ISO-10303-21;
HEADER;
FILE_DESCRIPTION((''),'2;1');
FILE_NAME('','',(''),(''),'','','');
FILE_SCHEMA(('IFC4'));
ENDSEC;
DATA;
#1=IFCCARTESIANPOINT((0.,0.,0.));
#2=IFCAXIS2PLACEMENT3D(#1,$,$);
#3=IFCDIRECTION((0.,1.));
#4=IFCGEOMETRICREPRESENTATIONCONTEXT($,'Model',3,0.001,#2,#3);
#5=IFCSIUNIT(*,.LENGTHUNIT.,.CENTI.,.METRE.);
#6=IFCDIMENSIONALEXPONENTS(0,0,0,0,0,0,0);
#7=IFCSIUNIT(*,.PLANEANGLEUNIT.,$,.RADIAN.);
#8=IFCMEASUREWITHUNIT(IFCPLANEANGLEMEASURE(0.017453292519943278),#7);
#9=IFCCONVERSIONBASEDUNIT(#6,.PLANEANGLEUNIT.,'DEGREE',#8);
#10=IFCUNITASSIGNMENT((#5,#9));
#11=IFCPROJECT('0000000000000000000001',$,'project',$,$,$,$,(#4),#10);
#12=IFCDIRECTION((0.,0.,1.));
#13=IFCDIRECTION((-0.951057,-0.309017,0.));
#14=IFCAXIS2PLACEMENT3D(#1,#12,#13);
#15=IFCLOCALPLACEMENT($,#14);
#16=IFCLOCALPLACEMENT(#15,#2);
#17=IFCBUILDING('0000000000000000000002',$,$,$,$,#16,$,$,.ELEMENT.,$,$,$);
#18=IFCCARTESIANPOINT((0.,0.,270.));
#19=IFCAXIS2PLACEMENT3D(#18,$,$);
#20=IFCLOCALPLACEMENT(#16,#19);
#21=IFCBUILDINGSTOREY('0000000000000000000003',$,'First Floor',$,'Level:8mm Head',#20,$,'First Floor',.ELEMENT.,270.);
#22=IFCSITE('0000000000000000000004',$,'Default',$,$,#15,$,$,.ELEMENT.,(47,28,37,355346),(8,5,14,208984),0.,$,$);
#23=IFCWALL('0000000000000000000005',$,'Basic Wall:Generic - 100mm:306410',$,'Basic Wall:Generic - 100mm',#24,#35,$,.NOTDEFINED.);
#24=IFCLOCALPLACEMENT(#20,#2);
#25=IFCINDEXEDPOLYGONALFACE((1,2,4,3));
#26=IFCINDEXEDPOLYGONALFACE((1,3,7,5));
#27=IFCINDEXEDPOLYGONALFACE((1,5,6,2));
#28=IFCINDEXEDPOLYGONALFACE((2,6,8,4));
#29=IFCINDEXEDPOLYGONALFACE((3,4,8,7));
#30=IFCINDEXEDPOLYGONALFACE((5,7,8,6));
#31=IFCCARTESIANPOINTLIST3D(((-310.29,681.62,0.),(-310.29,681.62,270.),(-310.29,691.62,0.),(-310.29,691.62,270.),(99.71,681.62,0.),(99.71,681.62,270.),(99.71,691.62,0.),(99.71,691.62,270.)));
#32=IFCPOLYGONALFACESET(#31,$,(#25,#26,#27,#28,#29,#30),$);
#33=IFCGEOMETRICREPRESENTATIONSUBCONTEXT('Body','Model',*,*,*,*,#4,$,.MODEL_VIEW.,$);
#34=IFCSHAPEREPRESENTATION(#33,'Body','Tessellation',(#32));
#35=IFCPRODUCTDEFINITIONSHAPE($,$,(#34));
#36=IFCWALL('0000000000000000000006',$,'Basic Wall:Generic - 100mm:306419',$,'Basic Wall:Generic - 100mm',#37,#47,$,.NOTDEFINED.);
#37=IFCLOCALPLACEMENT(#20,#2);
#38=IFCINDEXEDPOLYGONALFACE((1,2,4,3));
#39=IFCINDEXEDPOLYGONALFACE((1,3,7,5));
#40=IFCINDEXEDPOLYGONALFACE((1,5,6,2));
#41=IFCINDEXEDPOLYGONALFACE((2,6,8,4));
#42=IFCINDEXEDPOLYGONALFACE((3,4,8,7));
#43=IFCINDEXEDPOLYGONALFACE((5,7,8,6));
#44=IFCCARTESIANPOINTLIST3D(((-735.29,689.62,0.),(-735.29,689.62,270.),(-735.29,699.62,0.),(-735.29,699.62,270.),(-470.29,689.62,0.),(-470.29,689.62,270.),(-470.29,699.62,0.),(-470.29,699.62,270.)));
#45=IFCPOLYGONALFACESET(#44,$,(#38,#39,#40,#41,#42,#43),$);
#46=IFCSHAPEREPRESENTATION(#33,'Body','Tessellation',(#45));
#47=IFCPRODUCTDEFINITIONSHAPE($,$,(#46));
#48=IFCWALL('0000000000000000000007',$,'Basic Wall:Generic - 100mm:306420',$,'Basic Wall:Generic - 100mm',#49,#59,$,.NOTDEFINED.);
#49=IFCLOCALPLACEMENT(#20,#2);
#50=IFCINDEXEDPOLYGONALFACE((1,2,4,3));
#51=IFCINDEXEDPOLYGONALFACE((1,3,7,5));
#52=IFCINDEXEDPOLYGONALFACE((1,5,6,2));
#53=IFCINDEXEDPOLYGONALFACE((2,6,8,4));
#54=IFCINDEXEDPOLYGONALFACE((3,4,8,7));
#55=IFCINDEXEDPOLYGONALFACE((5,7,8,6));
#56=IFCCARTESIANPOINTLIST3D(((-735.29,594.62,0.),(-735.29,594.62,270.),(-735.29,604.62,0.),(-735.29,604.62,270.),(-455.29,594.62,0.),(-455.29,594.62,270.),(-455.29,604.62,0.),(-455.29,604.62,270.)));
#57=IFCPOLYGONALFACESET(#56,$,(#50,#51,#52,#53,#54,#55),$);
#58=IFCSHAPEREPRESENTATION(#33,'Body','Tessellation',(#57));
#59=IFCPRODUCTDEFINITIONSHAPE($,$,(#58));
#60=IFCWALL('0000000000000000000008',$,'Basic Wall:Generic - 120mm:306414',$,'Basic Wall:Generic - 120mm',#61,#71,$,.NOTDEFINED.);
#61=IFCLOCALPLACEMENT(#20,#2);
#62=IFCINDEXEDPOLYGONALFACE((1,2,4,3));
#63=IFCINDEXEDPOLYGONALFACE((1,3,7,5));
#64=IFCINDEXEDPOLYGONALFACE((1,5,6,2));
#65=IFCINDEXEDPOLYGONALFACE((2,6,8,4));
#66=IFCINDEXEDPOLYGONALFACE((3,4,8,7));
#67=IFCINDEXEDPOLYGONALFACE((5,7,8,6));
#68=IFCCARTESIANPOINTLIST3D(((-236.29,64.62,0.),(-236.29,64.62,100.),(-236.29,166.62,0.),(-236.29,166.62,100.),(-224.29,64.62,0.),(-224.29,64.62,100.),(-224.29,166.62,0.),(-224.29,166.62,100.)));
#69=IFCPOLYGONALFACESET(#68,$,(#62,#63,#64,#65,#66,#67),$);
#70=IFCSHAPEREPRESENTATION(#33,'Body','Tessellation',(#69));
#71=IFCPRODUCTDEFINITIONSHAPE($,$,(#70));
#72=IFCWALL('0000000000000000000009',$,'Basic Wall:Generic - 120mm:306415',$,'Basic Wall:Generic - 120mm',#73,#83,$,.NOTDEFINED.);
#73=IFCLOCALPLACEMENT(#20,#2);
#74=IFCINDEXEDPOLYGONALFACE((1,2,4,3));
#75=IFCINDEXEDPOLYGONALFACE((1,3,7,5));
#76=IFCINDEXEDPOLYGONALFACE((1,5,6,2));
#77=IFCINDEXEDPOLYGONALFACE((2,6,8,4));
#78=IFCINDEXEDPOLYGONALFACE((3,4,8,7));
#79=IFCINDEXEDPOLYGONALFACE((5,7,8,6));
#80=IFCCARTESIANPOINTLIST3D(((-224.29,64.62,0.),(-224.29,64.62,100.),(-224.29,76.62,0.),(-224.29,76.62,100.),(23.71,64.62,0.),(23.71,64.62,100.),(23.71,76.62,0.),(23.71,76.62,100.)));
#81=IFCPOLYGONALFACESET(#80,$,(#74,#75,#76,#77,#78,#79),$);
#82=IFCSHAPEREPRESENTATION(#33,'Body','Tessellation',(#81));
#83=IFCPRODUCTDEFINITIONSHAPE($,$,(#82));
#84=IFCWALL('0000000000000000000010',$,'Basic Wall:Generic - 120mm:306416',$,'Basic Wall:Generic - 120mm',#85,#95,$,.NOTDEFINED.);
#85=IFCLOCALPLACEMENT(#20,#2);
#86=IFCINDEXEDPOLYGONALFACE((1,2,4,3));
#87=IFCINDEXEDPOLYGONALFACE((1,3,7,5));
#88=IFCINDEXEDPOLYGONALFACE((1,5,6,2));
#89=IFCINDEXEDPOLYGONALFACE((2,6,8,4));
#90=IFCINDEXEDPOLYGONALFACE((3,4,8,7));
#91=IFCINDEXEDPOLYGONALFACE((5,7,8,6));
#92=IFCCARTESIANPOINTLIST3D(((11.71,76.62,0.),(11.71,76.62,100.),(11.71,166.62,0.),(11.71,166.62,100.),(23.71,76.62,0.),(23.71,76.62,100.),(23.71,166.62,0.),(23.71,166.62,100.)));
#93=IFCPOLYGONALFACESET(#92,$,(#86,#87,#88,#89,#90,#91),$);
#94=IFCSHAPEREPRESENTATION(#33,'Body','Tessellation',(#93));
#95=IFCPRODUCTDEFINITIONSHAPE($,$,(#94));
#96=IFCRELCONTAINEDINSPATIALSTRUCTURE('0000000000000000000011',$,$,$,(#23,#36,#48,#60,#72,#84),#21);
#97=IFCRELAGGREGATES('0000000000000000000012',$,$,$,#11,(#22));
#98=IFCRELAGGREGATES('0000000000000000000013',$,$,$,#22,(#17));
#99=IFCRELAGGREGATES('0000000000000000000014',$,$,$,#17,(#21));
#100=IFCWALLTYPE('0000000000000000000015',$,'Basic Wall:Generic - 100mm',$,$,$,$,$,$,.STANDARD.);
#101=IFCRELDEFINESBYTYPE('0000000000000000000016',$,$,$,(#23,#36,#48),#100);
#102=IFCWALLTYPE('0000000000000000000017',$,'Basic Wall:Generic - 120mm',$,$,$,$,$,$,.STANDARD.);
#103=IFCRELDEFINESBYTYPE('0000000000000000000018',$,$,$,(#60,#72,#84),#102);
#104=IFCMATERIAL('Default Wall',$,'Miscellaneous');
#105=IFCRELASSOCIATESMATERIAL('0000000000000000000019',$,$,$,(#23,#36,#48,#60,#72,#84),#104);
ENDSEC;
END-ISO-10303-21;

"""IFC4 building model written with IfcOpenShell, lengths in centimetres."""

from ifc_helpers import new_model, entity, si_unit, converted_unit, direction, frame, origin, place, context, subcontext, project, spatial, indexed_curve, outline, extrude, material, type_object, element, save


model = new_model("IFC4")

# Units and contexts
model_context = context("Model", 3, precision=0.001, world=origin(), true_north=direction((0.0, 1.0)))
body_context = subcontext(model_context, "Body", "Model", "MODEL_VIEW")
ifc_project = project(units=[si_unit("LENGTHUNIT", "METRE", prefix="CENTI"), converted_unit("PLANEANGLEUNIT", "DEGREE", entity("IfcPlaneAngleMeasure", 0.017453292519943278), si_unit("PLANEANGLEUNIT", "RADIAN"), dimensions=[0, 0, 0, 0, 0, 0, 0])], contexts=[model_context])

# Site, building, storey
site_placement = place(None, frame((0.0, 0.0, 0.0), z_axis=(0.0, 0.0, 1.0), x_axis=(-0.951057, -0.309017, 0.0)))
site = spatial("IfcSite", under=ifc_project, at=site_placement, Name="Default", CompositionType="ELEMENT", RefLatitude=(47, 28, 37, 355346), RefLongitude=(8, 5, 14, 208984), RefElevation=0.0)
building_placement = place(site_placement, origin())
building = spatial("IfcBuilding", under=site, at=building_placement, CompositionType="ELEMENT")
storey_placement = place(building_placement, frame((0.0, 0.0, 270.0)))
storey = spatial("IfcBuildingStorey", under=building, at=storey_placement, Name="First Floor", ObjectType="Level:8mm Head", LongName="First Floor", CompositionType="ELEMENT", Elevation=270.0)

# Walls
ifc_material_1 = material(Name="Default Wall", Category="Miscellaneous")
wall_type_1 = type_object("IfcWallType", Name="Basic Wall:Generic - 100mm", PredefinedType="STANDARD")
wall_1_placement = place(storey_placement, frame((-310.29, 686.62, 0.0)))
element("IfcWall", 1, at=wall_1_placement, inside=storey, type_object=wall_type_1, material=ifc_material_1, Name="Basic Wall:Generic - 100mm:306410", ObjectType="Basic Wall:Generic - 100mm", PredefinedType="NOTDEFINED", context=body_context, shape_type="SweptSolid", body=[
    extrude(outline(indexed_curve([(410.0, 5.0), (0.0, 5.0), (0.0, -5.0), (410.0, -5.0), (410.0, 5.0)], self_intersect=False)), origin(), (0.0, 0.0, 1.0), 270.0),
])
wall_2_placement = place(storey_placement, frame((-470.29, 694.62, 0.0), z_axis=(0.0, 0.0, 1.0), x_axis=(-1.0, 0.0, 0.0)))
element("IfcWall", 2, at=wall_2_placement, inside=storey, type_object=wall_type_1, material=ifc_material_1, Name="Basic Wall:Generic - 100mm:306419", ObjectType="Basic Wall:Generic - 100mm", PredefinedType="NOTDEFINED", context=body_context, shape_type="SweptSolid", body=[
    extrude(outline(indexed_curve([(265.0, 5.0), (0.0, 5.0), (0.0, -5.0), (265.0, -5.0), (265.0, 5.0)], self_intersect=False)), origin(), (0.0, 0.0, 1.0), 270.0),
])
wall_3_placement = place(storey_placement, frame((-735.29, 599.62, 0.0)))
element("IfcWall", 3, at=wall_3_placement, inside=storey, type_object=wall_type_1, material=ifc_material_1, Name="Basic Wall:Generic - 100mm:306420", ObjectType="Basic Wall:Generic - 100mm", PredefinedType="NOTDEFINED", context=body_context, shape_type="SweptSolid", body=[
    extrude(outline(indexed_curve([(280.0, 5.0), (0.0, 5.0), (0.0, -5.0), (280.0, -5.0), (280.0, 5.0)], self_intersect=False)), origin(), (0.0, 0.0, 1.0), 270.0),
])
wall_type_2 = type_object("IfcWallType", Name="Basic Wall:Generic - 120mm", PredefinedType="STANDARD")
wall_4_placement = place(storey_placement, frame((-230.29, 166.62, 0.0), z_axis=(0.0, 0.0, 1.0), x_axis=(0.0, -1.0, 0.0)))
element("IfcWall", 4, at=wall_4_placement, inside=storey, type_object=wall_type_2, material=ifc_material_1, Name="Basic Wall:Generic - 120mm:306414", ObjectType="Basic Wall:Generic - 120mm", PredefinedType="NOTDEFINED", context=body_context, shape_type="SweptSolid", body=[
    extrude(outline(indexed_curve([(102.0, 6.0), (0.0, 6.0), (0.0, -6.0), (102.0, -6.0), (102.0, 6.0)], self_intersect=False)), origin(), (0.0, 0.0, 1.0), 100.0),
])
wall_5_placement = place(storey_placement, frame((-224.29, 70.62, 0.0)))
element("IfcWall", 5, at=wall_5_placement, inside=storey, type_object=wall_type_2, material=ifc_material_1, Name="Basic Wall:Generic - 120mm:306415", ObjectType="Basic Wall:Generic - 120mm", PredefinedType="NOTDEFINED", context=body_context, shape_type="SweptSolid", body=[
    extrude(outline(indexed_curve([(248.0, 6.0), (0.0, 6.0), (0.0, -6.0), (248.0, -6.0), (248.0, 6.0)], self_intersect=False)), origin(), (0.0, 0.0, 1.0), 100.0),
])
wall_6_placement = place(storey_placement, frame((17.71, 76.62, 0.0), z_axis=(0.0, 0.0, 1.0), x_axis=(0.0, 1.0, 0.0)))
element("IfcWall", 6, at=wall_6_placement, inside=storey, type_object=wall_type_2, material=ifc_material_1, Name="Basic Wall:Generic - 120mm:306416", ObjectType="Basic Wall:Generic - 120mm", PredefinedType="NOTDEFINED", context=body_context, shape_type="SweptSolid", body=[
    extrude(outline(indexed_curve([(90.0, 6.0), (0.0, 6.0), (0.0, -6.0), (90.0, -6.0), (90.0, 6.0)], self_intersect=False)), origin(), (0.0, 0.0, 1.0), 100.0),
])

save(model, "model.ifc")
